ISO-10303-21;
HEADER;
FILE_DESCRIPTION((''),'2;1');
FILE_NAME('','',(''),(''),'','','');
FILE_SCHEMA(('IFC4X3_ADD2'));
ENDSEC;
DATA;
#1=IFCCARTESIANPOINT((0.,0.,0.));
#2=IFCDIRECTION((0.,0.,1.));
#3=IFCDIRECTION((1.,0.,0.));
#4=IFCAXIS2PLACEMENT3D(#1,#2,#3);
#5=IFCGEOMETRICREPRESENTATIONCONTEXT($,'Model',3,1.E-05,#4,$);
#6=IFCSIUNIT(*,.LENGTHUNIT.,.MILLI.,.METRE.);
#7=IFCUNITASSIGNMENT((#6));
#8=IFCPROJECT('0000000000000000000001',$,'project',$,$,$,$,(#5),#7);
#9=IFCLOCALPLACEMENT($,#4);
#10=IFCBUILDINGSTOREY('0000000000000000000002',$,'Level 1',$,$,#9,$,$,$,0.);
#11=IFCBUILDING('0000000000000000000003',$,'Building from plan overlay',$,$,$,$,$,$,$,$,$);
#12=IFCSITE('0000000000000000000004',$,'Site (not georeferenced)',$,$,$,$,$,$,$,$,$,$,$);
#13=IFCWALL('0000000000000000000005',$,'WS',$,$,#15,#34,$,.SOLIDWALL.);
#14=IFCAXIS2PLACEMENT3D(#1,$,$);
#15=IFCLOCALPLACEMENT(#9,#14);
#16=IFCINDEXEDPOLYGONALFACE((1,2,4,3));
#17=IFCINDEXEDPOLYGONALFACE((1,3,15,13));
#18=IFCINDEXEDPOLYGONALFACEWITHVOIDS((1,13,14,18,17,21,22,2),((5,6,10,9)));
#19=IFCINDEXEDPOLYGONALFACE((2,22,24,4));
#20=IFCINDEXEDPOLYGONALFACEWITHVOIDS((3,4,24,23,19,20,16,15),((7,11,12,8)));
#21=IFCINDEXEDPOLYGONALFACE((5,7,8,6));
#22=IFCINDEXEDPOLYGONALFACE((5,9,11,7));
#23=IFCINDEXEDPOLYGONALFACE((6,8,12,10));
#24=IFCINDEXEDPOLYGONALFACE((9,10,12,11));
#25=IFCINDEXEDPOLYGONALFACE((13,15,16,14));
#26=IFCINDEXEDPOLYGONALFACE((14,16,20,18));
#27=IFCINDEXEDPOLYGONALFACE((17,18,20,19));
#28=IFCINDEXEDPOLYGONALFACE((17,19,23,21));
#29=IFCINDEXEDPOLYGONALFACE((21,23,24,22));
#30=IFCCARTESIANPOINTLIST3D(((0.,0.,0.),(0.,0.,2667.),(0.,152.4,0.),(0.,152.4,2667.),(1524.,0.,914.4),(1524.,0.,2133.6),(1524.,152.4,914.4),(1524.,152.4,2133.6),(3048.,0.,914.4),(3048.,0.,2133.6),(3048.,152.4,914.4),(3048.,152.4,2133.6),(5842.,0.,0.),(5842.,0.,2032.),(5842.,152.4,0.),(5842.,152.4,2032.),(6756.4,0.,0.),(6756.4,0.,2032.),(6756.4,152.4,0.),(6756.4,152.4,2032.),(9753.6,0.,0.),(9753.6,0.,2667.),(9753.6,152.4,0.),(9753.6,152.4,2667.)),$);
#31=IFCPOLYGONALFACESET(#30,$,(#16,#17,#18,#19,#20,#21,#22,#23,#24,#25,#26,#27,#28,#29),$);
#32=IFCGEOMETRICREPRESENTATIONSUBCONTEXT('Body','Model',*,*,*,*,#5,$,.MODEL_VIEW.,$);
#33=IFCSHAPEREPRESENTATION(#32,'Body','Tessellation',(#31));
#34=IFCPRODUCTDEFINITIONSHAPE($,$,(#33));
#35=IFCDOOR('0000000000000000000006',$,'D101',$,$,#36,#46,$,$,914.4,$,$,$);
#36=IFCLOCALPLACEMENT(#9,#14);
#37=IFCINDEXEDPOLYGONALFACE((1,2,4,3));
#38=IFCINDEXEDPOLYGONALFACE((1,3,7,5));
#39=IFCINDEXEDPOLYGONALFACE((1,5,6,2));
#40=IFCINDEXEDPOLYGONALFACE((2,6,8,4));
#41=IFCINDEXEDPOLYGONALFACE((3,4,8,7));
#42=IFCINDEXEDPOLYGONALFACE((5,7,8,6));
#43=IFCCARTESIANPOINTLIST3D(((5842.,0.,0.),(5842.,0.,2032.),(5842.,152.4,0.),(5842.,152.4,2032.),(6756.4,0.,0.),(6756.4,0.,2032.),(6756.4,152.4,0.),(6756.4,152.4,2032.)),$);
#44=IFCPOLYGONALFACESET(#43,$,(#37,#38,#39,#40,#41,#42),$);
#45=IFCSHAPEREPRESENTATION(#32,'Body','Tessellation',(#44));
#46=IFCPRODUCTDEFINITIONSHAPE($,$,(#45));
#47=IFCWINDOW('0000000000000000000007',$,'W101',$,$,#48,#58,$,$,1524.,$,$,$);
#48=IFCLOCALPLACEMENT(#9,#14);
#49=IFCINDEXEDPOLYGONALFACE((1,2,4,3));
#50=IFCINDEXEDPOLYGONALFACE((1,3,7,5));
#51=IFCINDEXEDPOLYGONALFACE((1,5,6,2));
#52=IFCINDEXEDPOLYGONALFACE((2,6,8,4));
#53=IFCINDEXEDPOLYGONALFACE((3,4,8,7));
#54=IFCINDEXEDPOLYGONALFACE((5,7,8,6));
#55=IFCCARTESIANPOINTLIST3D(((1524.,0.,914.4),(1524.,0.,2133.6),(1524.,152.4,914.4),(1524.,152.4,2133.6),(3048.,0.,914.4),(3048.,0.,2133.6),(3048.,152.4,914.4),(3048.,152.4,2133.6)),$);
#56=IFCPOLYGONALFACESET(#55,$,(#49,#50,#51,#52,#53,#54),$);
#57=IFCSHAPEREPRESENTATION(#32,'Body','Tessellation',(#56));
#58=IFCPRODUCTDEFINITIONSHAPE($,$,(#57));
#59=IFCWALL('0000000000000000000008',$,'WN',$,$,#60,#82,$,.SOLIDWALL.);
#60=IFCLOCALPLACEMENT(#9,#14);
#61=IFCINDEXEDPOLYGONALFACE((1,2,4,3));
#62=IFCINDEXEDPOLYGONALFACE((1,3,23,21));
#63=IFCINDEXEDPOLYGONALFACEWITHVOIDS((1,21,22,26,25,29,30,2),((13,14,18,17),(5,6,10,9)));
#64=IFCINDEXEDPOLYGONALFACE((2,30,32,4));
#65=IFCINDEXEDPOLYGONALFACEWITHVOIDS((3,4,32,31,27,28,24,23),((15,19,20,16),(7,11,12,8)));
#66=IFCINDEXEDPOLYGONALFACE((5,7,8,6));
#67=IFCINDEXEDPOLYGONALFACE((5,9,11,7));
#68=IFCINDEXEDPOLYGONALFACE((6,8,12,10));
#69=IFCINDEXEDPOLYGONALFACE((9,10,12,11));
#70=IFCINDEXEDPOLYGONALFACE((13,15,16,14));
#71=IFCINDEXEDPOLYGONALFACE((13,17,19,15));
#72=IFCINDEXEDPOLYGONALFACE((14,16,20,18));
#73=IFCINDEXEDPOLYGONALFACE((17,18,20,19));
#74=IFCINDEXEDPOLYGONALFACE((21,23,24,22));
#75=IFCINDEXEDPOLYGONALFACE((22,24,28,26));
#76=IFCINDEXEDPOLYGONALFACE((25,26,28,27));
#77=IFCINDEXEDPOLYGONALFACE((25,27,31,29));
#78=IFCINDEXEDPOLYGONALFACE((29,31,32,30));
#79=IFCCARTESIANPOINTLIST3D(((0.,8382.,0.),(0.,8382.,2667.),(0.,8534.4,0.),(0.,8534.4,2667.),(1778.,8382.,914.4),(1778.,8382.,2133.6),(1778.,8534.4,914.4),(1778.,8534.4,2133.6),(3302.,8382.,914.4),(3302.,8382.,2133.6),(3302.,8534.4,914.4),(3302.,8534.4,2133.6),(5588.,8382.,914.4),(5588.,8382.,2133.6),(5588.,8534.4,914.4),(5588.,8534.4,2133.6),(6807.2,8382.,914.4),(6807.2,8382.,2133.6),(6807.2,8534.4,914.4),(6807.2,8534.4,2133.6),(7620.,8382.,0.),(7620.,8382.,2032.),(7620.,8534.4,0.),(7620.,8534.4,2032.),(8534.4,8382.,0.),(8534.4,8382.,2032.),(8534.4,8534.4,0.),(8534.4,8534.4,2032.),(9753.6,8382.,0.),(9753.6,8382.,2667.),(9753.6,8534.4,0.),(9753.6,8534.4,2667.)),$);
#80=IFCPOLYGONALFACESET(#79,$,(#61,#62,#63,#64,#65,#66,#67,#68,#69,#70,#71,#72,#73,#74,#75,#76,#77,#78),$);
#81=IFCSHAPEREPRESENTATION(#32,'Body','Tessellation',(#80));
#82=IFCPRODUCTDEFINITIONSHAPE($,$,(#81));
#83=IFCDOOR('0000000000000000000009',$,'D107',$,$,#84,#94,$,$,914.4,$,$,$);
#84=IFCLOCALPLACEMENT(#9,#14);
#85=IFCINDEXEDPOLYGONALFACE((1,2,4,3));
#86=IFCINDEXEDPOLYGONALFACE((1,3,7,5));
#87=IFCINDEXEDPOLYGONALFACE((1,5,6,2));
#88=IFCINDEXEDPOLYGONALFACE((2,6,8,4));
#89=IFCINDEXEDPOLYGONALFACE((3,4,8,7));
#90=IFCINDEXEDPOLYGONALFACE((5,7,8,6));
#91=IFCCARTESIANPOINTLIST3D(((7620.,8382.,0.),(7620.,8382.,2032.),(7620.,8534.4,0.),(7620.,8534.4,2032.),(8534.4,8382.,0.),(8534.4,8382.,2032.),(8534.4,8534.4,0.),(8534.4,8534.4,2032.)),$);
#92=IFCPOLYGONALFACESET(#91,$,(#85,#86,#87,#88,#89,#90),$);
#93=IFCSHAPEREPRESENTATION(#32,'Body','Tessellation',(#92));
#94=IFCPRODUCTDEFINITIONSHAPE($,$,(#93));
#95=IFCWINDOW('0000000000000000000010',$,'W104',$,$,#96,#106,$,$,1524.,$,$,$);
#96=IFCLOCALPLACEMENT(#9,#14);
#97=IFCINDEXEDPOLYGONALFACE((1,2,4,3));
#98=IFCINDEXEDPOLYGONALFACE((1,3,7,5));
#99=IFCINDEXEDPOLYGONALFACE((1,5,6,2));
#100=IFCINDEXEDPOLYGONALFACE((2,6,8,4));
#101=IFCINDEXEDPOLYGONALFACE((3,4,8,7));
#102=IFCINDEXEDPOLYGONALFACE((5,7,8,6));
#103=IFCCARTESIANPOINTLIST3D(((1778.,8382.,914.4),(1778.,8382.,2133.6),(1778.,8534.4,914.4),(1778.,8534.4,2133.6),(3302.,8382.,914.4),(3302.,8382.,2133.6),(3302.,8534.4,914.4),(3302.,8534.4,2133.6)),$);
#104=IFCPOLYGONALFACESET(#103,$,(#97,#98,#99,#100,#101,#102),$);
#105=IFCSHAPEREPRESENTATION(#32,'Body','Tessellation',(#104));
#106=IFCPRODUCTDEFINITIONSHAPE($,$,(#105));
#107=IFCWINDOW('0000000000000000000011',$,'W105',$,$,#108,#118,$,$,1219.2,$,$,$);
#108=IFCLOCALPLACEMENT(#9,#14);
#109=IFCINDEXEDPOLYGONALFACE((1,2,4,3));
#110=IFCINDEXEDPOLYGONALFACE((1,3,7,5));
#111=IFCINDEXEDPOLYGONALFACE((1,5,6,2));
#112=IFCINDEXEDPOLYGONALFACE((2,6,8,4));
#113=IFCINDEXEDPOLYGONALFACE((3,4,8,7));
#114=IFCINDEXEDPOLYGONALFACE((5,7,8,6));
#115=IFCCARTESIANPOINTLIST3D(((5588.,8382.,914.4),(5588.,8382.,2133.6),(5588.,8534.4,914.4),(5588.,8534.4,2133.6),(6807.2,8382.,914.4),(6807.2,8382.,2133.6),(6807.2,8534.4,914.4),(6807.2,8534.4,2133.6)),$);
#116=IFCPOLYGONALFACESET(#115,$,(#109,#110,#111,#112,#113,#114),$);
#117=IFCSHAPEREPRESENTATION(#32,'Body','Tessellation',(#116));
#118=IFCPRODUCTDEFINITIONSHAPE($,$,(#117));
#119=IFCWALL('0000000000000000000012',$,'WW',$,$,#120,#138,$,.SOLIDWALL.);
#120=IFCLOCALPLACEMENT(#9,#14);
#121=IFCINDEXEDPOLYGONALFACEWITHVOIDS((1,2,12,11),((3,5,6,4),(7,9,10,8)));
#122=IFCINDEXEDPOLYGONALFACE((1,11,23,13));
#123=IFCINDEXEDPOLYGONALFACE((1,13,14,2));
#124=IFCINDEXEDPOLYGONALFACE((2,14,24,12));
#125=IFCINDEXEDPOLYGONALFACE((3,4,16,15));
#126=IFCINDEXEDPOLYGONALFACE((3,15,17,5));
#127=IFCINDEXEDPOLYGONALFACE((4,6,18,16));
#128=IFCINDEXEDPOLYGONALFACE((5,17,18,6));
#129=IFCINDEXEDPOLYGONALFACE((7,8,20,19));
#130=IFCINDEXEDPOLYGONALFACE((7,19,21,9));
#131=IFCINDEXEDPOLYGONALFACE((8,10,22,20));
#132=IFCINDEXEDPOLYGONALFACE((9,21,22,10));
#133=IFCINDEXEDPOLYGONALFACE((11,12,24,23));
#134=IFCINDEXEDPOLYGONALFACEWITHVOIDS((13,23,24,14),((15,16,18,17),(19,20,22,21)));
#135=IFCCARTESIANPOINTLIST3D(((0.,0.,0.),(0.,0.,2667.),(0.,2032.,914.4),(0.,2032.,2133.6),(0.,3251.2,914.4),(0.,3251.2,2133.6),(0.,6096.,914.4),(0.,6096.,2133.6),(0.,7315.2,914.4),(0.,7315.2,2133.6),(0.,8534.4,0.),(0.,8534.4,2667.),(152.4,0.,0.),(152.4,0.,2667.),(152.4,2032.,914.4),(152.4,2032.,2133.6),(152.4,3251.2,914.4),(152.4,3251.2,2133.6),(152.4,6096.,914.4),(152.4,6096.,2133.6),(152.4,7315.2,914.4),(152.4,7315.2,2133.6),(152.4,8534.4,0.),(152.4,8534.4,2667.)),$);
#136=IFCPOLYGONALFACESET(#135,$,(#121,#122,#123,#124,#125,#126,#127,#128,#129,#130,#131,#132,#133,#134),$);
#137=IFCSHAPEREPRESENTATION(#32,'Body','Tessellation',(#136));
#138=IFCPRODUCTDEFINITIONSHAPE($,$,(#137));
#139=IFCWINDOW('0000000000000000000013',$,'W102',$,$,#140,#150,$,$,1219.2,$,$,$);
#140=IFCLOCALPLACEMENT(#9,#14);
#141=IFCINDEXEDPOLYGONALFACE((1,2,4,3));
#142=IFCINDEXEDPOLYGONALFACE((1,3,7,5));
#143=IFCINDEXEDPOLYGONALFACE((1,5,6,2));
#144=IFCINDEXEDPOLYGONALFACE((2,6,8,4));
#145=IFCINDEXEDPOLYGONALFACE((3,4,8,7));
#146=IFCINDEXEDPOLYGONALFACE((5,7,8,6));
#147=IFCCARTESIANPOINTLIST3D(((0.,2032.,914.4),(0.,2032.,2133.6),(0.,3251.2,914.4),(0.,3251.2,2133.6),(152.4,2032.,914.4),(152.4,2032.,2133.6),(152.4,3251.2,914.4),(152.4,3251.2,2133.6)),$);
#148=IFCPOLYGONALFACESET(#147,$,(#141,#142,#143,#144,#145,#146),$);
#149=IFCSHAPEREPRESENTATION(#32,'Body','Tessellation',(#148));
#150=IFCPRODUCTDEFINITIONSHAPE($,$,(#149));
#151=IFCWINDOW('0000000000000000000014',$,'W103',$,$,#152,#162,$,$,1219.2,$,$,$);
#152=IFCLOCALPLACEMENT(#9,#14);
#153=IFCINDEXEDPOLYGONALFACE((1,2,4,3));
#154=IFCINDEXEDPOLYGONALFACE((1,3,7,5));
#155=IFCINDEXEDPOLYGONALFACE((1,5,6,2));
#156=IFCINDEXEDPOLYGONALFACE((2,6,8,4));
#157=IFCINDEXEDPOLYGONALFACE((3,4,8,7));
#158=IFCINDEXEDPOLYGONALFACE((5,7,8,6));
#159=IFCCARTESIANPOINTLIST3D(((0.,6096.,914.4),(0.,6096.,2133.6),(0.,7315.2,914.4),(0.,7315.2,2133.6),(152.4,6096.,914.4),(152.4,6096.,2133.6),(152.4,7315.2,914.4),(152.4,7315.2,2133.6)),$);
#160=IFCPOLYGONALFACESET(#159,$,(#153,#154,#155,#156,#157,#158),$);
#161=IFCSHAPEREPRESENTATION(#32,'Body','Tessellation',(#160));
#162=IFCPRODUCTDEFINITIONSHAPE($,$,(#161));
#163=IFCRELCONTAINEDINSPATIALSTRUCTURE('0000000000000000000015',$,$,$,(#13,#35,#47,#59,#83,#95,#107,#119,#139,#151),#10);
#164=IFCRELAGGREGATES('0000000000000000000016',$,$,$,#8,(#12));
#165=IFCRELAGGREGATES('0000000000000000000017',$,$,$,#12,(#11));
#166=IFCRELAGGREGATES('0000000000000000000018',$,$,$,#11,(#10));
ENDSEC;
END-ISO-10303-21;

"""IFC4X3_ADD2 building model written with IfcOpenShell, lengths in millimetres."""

from ifc_helpers import new_model, si_unit, frame, origin, origin_with_axes, place, context, subcontext, project, spatial, polyline, outline, extrude, element, fill, save


model = new_model("IFC4X3_ADD2")

# Units and contexts
model_context = context("Model", 3, precision=1e-05, world=origin_with_axes())
body_context = subcontext(model_context, "Body", "Model", "MODEL_VIEW")
ifc_project = project(units=[si_unit("LENGTHUNIT", "METRE", prefix="MILLI")], contexts=[model_context])

# Site, building, storey
site = spatial("IfcSite", under=ifc_project, Name="Site (not georeferenced)")
building = spatial("IfcBuilding", under=site, Name="Building from plan overlay")
storey_placement = place(None, origin_with_axes())
storey = spatial("IfcBuildingStorey", under=building, at=storey_placement, Name="Level 1", Elevation=0.0)

# Wall, openings, door, window
wall_1_placement = place(storey_placement, origin_with_axes())
wall_1 = element("IfcWall", 1, at=wall_1_placement, inside=storey, Name="WS", PredefinedType="SOLIDWALL", context=body_context, shape_type="SweptSolid", body=[
    extrude(outline(polyline([(0.0, 0.0), (9753.6, 0.0), (9753.6, 152.4), (0.0, 152.4), (0.0, 0.0)])), origin(), (0.0, 0.0, 1.0), 2667.0),
])
opening_1_placement = place(wall_1_placement, origin_with_axes())
opening_1 = element("IfcOpeningElement", 2, at=opening_1_placement, cuts=wall_1, context=body_context, shape_type="SweptSolid", body=[
    extrude(outline(polyline([(5842.0, 0.0), (6756.4, 0.0), (6756.4, 152.4), (5842.0, 152.4), (5842.0, 0.0)])), origin(), (0.0, 0.0, 1.0), 2032.0),
])
opening_2_placement = place(wall_1_placement, origin_with_axes())
opening_2 = element("IfcOpeningElement", 3, at=opening_2_placement, cuts=wall_1, context=body_context, shape_type="SweptSolid", body=[
    extrude(outline(polyline([(1524.0, 0.0), (3048.0, 0.0), (3048.0, 152.4), (1524.0, 152.4), (1524.0, 0.0)])), frame((0.0, 0.0, 914.4)), (0.0, 0.0, 1.0), 1219.2),
])
door_1_placement = place(storey_placement, origin_with_axes())
door_1 = element("IfcDoor", 4, at=door_1_placement, inside=storey, Name="D101", OverallWidth=914.4, context=body_context, shape_type="SweptSolid", body=[
    extrude(outline(polyline([(5842.0, 0.0), (6756.4, 0.0), (6756.4, 152.4), (5842.0, 152.4), (5842.0, 0.0)])), origin(), (0.0, 0.0, 1.0), 2032.0),
])
fill(opening_1, door_1)
window_1_placement = place(storey_placement, origin_with_axes())
window_1 = element("IfcWindow", 5, at=window_1_placement, inside=storey, Name="W101", OverallWidth=1524.0, context=body_context, shape_type="SweptSolid", body=[
    extrude(outline(polyline([(1524.0, 0.0), (3048.0, 0.0), (3048.0, 152.4), (1524.0, 152.4), (1524.0, 0.0)])), frame((0.0, 0.0, 914.4)), (0.0, 0.0, 1.0), 1219.2),
])
fill(opening_2, window_1)

# Wall, openings, door, windows
wall_2_placement = place(storey_placement, origin_with_axes())
wall_2 = element("IfcWall", 6, at=wall_2_placement, inside=storey, Name="WN", PredefinedType="SOLIDWALL", context=body_context, shape_type="SweptSolid", body=[
    extrude(outline(polyline([(0.0, 8382.0), (9753.6, 8382.0), (9753.6, 8534.4), (0.0, 8534.4), (0.0, 8382.0)])), origin(), (0.0, 0.0, 1.0), 2667.0),
])
opening_3_placement = place(wall_2_placement, origin_with_axes())
opening_3 = element("IfcOpeningElement", 7, at=opening_3_placement, cuts=wall_2, context=body_context, shape_type="SweptSolid", body=[
    extrude(outline(polyline([(7620.0, 8382.0), (8534.4, 8382.0), (8534.4, 8534.4), (7620.0, 8534.4), (7620.0, 8382.0)])), origin(), (0.0, 0.0, 1.0), 2032.0),
])
opening_4_placement = place(wall_2_placement, origin_with_axes())
opening_4 = element("IfcOpeningElement", 8, at=opening_4_placement, cuts=wall_2, context=body_context, shape_type="SweptSolid", body=[
    extrude(outline(polyline([(1778.0, 8382.0), (3302.0, 8382.0), (3302.0, 8534.4), (1778.0, 8534.4), (1778.0, 8382.0)])), frame((0.0, 0.0, 914.4)), (0.0, 0.0, 1.0), 1219.2),
])
opening_5_placement = place(wall_2_placement, origin_with_axes())
opening_5 = element("IfcOpeningElement", 9, at=opening_5_placement, cuts=wall_2, context=body_context, shape_type="SweptSolid", body=[
    extrude(outline(polyline([(5588.0, 8382.0), (6807.2, 8382.0), (6807.2, 8534.4), (5588.0, 8534.4), (5588.0, 8382.0)])), frame((0.0, 0.0, 914.4)), (0.0, 0.0, 1.0), 1219.2),
])
door_2_placement = place(storey_placement, origin_with_axes())
door_2 = element("IfcDoor", 10, at=door_2_placement, inside=storey, Name="D107", OverallWidth=914.4, context=body_context, shape_type="SweptSolid", body=[
    extrude(outline(polyline([(7620.0, 8382.0), (8534.4, 8382.0), (8534.4, 8534.4), (7620.0, 8534.4), (7620.0, 8382.0)])), origin(), (0.0, 0.0, 1.0), 2032.0),
])
fill(opening_3, door_2)
window_2_placement = place(storey_placement, origin_with_axes())
window_2 = element("IfcWindow", 11, at=window_2_placement, inside=storey, Name="W104", OverallWidth=1524.0, context=body_context, shape_type="SweptSolid", body=[
    extrude(outline(polyline([(1778.0, 8382.0), (3302.0, 8382.0), (3302.0, 8534.4), (1778.0, 8534.4), (1778.0, 8382.0)])), frame((0.0, 0.0, 914.4)), (0.0, 0.0, 1.0), 1219.2),
])
fill(opening_4, window_2)
window_3_placement = place(storey_placement, origin_with_axes())
window_3 = element("IfcWindow", 12, at=window_3_placement, inside=storey, Name="W105", OverallWidth=1219.2, context=body_context, shape_type="SweptSolid", body=[
    extrude(outline(polyline([(5588.0, 8382.0), (6807.2, 8382.0), (6807.2, 8534.4), (5588.0, 8534.4), (5588.0, 8382.0)])), frame((0.0, 0.0, 914.4)), (0.0, 0.0, 1.0), 1219.2),
])
fill(opening_5, window_3)

# Wall, openings, windows
wall_3_placement = place(storey_placement, origin_with_axes())
wall_3 = element("IfcWall", 13, at=wall_3_placement, inside=storey, Name="WW", PredefinedType="SOLIDWALL", context=body_context, shape_type="SweptSolid", body=[
    extrude(outline(polyline([(0.0, 0.0), (152.4, 0.0), (152.4, 8534.4), (0.0, 8534.4), (0.0, 0.0)])), origin(), (0.0, 0.0, 1.0), 2667.0),
])
opening_6_placement = place(wall_3_placement, origin_with_axes())
opening_6 = element("IfcOpeningElement", 14, at=opening_6_placement, cuts=wall_3, context=body_context, shape_type="SweptSolid", body=[
    extrude(outline(polyline([(0.0, 2032.0), (152.4, 2032.0), (152.4, 3251.2), (0.0, 3251.2), (0.0, 2032.0)])), frame((0.0, 0.0, 914.4)), (0.0, 0.0, 1.0), 1219.2),
])
opening_7_placement = place(wall_3_placement, origin_with_axes())
opening_7 = element("IfcOpeningElement", 15, at=opening_7_placement, cuts=wall_3, context=body_context, shape_type="SweptSolid", body=[
    extrude(outline(polyline([(0.0, 6096.0), (152.4, 6096.0), (152.4, 7315.2), (0.0, 7315.2), (0.0, 6096.0)])), frame((0.0, 0.0, 914.4)), (0.0, 0.0, 1.0), 1219.2),
])
window_4_placement = place(storey_placement, origin_with_axes())
window_4 = element("IfcWindow", 16, at=window_4_placement, inside=storey, Name="W102", OverallWidth=1219.2, context=body_context, shape_type="SweptSolid", body=[
    extrude(outline(polyline([(0.0, 2032.0), (152.4, 2032.0), (152.4, 3251.2), (0.0, 3251.2), (0.0, 2032.0)])), frame((0.0, 0.0, 914.4)), (0.0, 0.0, 1.0), 1219.2),
])
fill(opening_6, window_4)
window_5_placement = place(storey_placement, origin_with_axes())
window_5 = element("IfcWindow", 17, at=window_5_placement, inside=storey, Name="W103", OverallWidth=1219.2, context=body_context, shape_type="SweptSolid", body=[
    extrude(outline(polyline([(0.0, 6096.0), (152.4, 6096.0), (152.4, 7315.2), (0.0, 7315.2), (0.0, 6096.0)])), frame((0.0, 0.0, 914.4)), (0.0, 0.0, 1.0), 1219.2),
])
fill(opening_7, window_5)

save(model, "model.ifc")
